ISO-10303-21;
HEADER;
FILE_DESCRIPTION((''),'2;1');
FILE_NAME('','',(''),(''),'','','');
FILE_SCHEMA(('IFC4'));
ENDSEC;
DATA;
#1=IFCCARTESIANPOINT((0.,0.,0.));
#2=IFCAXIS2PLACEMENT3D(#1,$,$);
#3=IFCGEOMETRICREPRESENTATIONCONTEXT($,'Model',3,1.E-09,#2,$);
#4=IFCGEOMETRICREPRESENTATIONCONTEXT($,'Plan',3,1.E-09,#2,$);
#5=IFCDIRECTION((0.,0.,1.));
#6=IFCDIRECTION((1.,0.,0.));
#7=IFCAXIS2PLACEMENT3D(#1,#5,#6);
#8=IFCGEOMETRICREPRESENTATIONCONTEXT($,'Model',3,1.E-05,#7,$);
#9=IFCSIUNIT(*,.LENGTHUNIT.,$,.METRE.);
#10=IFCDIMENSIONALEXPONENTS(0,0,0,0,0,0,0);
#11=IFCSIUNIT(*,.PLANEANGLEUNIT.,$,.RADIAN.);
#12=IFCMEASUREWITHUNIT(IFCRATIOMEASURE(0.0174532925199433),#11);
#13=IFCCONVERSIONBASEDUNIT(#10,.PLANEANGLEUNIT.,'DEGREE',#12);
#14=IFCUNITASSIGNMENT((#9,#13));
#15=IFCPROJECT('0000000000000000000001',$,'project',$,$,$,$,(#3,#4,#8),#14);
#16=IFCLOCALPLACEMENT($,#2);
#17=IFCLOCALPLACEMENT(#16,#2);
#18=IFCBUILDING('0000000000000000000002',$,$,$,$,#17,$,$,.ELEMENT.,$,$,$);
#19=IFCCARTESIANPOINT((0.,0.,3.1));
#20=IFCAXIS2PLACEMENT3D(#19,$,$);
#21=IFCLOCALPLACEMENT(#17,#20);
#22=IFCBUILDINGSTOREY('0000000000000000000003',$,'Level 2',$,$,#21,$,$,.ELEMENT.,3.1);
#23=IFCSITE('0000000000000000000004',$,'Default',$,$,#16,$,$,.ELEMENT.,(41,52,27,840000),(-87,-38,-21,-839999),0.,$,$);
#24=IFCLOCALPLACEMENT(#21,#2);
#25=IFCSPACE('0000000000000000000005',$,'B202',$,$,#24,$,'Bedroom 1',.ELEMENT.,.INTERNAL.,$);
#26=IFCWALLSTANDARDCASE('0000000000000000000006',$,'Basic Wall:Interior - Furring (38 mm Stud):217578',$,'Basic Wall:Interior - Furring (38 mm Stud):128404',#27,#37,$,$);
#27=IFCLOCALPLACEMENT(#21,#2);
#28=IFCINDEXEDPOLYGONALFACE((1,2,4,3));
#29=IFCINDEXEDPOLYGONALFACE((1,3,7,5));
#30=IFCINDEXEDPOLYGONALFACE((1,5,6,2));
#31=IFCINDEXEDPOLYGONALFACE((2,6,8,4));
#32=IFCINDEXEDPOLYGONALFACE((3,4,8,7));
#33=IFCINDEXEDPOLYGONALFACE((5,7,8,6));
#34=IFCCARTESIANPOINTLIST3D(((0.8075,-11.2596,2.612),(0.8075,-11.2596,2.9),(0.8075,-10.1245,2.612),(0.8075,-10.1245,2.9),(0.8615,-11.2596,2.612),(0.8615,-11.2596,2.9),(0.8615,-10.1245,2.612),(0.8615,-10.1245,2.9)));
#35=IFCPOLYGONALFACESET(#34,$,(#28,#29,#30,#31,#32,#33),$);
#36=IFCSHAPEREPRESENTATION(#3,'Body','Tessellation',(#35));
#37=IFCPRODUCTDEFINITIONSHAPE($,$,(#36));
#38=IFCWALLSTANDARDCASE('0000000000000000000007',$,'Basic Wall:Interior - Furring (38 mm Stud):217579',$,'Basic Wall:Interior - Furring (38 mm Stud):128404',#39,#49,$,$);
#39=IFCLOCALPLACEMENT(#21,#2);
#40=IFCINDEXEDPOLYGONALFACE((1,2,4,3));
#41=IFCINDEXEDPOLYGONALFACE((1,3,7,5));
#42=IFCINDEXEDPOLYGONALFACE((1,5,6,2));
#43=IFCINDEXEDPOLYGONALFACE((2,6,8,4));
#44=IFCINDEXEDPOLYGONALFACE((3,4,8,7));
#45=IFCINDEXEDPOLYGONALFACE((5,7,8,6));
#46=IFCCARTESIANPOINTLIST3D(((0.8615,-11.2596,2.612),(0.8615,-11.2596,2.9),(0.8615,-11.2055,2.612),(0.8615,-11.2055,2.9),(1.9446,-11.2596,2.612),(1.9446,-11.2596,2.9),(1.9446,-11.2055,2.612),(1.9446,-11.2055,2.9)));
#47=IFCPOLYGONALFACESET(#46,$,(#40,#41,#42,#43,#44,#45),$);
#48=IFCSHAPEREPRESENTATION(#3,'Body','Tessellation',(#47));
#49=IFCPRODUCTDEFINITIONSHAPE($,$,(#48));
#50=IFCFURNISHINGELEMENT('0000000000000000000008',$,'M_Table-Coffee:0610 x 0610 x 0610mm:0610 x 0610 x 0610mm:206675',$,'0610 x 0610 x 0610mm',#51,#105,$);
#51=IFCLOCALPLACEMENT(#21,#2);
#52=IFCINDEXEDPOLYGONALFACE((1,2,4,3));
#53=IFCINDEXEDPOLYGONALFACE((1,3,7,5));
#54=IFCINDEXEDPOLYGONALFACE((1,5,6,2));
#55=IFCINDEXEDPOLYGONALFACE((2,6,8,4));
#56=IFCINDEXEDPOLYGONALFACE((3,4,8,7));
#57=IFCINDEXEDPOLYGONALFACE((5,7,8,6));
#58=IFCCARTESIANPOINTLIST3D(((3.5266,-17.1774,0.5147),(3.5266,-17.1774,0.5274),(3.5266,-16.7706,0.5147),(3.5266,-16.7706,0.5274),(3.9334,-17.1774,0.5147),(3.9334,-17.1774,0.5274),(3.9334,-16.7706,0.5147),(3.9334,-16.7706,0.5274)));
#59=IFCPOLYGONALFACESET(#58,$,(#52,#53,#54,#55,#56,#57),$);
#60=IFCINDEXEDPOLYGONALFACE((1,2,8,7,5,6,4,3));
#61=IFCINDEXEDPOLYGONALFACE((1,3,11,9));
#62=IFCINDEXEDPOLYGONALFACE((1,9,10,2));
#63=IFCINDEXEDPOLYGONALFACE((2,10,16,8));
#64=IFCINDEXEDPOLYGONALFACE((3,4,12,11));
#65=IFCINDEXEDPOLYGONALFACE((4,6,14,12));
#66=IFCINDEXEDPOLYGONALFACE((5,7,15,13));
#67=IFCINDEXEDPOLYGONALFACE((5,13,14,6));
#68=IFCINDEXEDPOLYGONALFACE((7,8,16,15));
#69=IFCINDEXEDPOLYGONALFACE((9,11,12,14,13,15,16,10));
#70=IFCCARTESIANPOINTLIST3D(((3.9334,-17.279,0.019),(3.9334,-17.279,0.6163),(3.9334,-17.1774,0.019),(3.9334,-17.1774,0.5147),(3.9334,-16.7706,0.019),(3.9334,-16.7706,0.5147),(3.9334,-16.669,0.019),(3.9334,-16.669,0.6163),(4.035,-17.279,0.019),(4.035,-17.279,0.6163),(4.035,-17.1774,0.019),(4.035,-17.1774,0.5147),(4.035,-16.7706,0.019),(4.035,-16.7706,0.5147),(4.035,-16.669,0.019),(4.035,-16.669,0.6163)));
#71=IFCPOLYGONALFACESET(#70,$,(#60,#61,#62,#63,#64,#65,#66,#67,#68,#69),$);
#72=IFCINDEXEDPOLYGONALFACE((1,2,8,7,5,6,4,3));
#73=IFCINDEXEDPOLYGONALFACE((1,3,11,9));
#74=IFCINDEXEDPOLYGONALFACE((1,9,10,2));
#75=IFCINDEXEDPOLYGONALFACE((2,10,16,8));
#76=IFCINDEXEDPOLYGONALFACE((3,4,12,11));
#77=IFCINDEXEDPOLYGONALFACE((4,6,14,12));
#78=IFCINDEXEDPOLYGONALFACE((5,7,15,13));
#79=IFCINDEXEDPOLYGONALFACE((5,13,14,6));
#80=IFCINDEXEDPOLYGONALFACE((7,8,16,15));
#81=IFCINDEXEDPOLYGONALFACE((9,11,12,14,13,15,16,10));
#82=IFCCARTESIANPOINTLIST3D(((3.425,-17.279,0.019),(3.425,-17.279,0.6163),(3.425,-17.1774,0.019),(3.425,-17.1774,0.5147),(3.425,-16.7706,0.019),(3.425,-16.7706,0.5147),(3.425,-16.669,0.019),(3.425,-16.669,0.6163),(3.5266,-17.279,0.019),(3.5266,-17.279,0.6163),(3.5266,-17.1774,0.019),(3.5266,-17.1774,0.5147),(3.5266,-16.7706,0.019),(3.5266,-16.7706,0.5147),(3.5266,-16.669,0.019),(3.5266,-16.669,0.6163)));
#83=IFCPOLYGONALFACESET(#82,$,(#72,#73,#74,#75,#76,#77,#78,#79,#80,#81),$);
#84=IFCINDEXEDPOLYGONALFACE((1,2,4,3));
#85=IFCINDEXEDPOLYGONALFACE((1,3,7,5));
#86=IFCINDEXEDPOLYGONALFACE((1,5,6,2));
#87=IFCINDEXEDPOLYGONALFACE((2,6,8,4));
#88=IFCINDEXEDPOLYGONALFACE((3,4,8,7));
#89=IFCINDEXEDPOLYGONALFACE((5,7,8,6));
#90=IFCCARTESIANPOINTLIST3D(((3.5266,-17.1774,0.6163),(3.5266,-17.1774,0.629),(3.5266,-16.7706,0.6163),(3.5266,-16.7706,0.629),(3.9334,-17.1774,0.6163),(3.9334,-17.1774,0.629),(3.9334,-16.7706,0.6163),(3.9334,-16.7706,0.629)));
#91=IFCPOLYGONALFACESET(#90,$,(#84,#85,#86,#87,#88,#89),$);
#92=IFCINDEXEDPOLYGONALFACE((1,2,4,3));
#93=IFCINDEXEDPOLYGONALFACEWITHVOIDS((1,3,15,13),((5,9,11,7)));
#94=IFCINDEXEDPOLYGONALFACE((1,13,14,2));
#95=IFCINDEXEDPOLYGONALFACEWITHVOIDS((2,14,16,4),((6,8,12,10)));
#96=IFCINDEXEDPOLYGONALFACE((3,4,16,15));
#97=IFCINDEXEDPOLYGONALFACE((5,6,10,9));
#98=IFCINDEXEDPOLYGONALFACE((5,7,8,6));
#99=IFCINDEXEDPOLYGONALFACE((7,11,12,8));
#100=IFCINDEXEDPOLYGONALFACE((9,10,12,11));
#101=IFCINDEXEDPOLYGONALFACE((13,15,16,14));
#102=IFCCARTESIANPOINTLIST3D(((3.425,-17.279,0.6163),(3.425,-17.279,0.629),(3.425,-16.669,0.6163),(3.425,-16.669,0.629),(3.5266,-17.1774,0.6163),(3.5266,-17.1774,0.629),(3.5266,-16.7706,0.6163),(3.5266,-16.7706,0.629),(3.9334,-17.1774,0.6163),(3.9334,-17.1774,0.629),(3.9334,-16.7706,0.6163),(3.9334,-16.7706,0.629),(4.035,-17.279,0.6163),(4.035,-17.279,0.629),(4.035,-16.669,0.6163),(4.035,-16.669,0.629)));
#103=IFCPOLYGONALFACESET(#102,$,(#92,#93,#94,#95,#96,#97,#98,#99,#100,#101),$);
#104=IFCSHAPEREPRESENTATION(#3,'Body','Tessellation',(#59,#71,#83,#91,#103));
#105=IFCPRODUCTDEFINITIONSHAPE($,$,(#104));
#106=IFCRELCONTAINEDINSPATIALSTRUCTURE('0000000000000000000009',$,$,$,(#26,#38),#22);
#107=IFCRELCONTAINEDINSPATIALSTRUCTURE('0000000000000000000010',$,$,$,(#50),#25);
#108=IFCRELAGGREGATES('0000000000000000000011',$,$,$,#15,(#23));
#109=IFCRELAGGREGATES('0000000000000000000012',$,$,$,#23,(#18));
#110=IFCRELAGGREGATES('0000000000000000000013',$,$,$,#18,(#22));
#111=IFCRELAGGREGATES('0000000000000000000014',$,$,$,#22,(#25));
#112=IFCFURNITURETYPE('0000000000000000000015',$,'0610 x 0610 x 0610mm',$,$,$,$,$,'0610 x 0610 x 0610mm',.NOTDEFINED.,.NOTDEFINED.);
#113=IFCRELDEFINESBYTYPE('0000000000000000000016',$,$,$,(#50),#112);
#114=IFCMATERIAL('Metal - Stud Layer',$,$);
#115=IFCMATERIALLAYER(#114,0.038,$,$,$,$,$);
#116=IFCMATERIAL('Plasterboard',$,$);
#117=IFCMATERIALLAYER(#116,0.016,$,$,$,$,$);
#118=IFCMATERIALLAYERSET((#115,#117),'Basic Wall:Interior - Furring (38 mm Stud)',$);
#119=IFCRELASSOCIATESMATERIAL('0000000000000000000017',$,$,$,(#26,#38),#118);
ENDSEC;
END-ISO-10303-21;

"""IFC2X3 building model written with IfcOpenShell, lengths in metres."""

from ifc_helpers import new_model, entity, si_unit, converted_unit, frame, frame_2d, origin, origin_with_axes, origin_2d_with_axis, place, context, project, spatial, polyline, rectangle, outline, extrude, source, transform, mapped, material, layer, layer_set, layer_usage, type_object, type_shapes, element, save


model = new_model("IFC2X3")

# Units and contexts
model_context_1 = context("Model", 3, precision=1e-09, world=origin())
plan_context = context("Plan", 3, precision=1e-09, world=origin())
model_context_2 = context("Model", 3, precision=1e-05, world=origin_with_axes())
ifc_project = project(units=[si_unit("LENGTHUNIT", "METRE"), converted_unit("PLANEANGLEUNIT", "DEGREE", entity("IfcRatioMeasure", 0.0174532925199433), si_unit("PLANEANGLEUNIT", "RADIAN"), dimensions=[0, 0, 0, 0, 0, 0, 0])], contexts=[model_context_1, plan_context, model_context_2])

# Site, building, storey
site_placement = place(None, origin())
site = spatial("IfcSite", under=ifc_project, at=site_placement, Name="Default", CompositionType="ELEMENT", RefLatitude=(41, 52, 27, 840000), RefLongitude=(-87, -38, -21, -839999), RefElevation=0.0)
building_placement = place(site_placement, origin())
building = spatial("IfcBuilding", under=site, at=building_placement, CompositionType="ELEMENT")
storey_placement = place(building_placement, frame((0.0, 0.0, 3.1)))
storey = spatial("IfcBuildingStorey", under=building, at=storey_placement, Name="Level 2", CompositionType="ELEMENT", Elevation=3.1)

# Shared definitions
ifc_material_1 = material(Name="Metal - Stud Layer")
ifc_material_2 = material(Name="Plasterboard")

# Walls
ifc_layer_1 = layer(ifc_material_1, 0.038)
ifc_layer_2 = layer(ifc_material_2, 0.016)
ifc_layer_set_1 = layer_set([ifc_layer_1, ifc_layer_2], Name="Basic Wall:Interior - Furring (38 mm Stud)")
ifc_layer_usage_1 = layer_usage(ifc_layer_set_1, "AXIS2", "NEGATIVE", 0.027)
wall_1_placement = place(storey_placement, frame((0.8345, -11.2596, 2.612), z_axis=(0.0, 0.0, 1.0), x_axis=(0.0, 1.0, 0.0)))
element("IfcWallStandardCase", 1, at=wall_1_placement, inside=storey, material=ifc_layer_usage_1, Name="Basic Wall:Interior - Furring (38 mm Stud):217578", ObjectType="Basic Wall:Interior - Furring (38 mm Stud):128404", context=model_context_1, shape_type="SweptSolid", body=[
    extrude(rectangle(XDim=1.1351, YDim=0.054, at=frame_2d((0.5675, 0.0), x_axis=(-1.0, 0.0))), origin(), (0.0, 0.0, 1.0), 0.288),
])
ifc_layer_usage_2 = layer_usage(ifc_layer_set_1, "AXIS2", "NEGATIVE", 0.027)
wall_2_placement = place(storey_placement, frame((1.9446, -11.2325, 2.612), z_axis=(0.0, 0.0, 1.0), x_axis=(-1.0, 0.0, 0.0)))
element("IfcWallStandardCase", 2, at=wall_2_placement, inside=storey, material=ifc_layer_usage_2, Name="Basic Wall:Interior - Furring (38 mm Stud):217579", ObjectType="Basic Wall:Interior - Furring (38 mm Stud):128404", context=model_context_1, shape_type="SweptSolid", body=[
    extrude(rectangle(XDim=1.0831, YDim=0.054, at=frame_2d((0.5415, 0.0), x_axis=(-1.0, 0.0))), origin(), (0.0, 0.0, 1.0), 0.288),
])

# Shared definitions
space_placement = place(storey_placement, origin())
space = spatial("IfcSpace", under=storey, at=space_placement, Name="B202", LongName="Bedroom 1", CompositionType="ELEMENT", InteriorOrExteriorSpace="INTERNAL")

# Furnishing element
furniture_type = type_object("IfcFurnitureType", Name="0610 x 0610 x 0610mm", ElementType="0610 x 0610 x 0610mm", AssemblyPlace="NOTDEFINED")
shared_shape_1 = source(origin(), model_context_1, "Body", "SweptSolid", [
    extrude(rectangle(XDim=0.4068, YDim=0.4068, at=origin_2d_with_axis()), frame((0.0183, 0.0952, 0.4957), z_axis=(0.0, 0.0, 1.0), x_axis=(-1.0, 0.0, 0.0)), (0.0, 0.0, 1.0), 0.0127),
    extrude(outline(polyline([(-0.2732, -0.305), (0.324, -0.305), (0.324, 0.305), (-0.2732, 0.305), (-0.2732, 0.2034), (0.2225, 0.2034), (0.2225, -0.2034), (-0.2732, -0.2034), (-0.2732, -0.305)])), frame((0.2217, 0.0952, 0.2732), z_axis=(1.0, 0.0, 0.0), x_axis=(0.0, 0.0, 1.0)), (0.0, 0.0, 1.0), 0.1016),
    extrude(outline(polyline([(-0.305, -0.3241), (0.305, -0.3241), (0.305, 0.2733), (0.2034, 0.2733), (0.2034, -0.2224), (-0.2034, -0.2224), (-0.2034, 0.2733), (-0.305, 0.2733), (-0.305, -0.3241)])), frame((-0.2867, 0.0952, 0.2733), z_axis=(1.0, 0.0, 0.0), x_axis=(0.0, -1.0, 0.0)), (0.0, 0.0, 1.0), 0.1016),
    extrude(rectangle(XDim=0.4068, YDim=0.4068, at=origin_2d_with_axis()), frame((0.0183, 0.0952, 0.5973), z_axis=(0.0, 0.0, 1.0), x_axis=(-1.0, 0.0, 0.0)), (0.0, 0.0, 1.0), 0.0127),
    extrude(outline(polyline([(-0.305, -0.305), (0.305, -0.305), (0.305, 0.305), (-0.305, 0.305), (-0.305, -0.305)]), holes=[polyline([(-0.2034, -0.2034), (-0.2034, 0.2034), (0.2034, 0.2034), (0.2034, -0.2034), (-0.2034, -0.2034)])]), frame((0.0183, 0.0952, 0.5973), z_axis=(0.0, 0.0, 1.0), x_axis=(-1.0, 0.0, 0.0)), (0.0, 0.0, 1.0), 0.0127),
])
type_shapes(furniture_type, [shared_shape_1])
furnishing_placement = place(space_placement, frame((3.7117, -17.0692, 0.019)))
element("IfcFurnishingElement", 3, at=furnishing_placement, inside=space, type_object=furniture_type, Name="M_Table-Coffee:0610 x 0610 x 0610mm:0610 x 0610 x 0610mm:206675", ObjectType="0610 x 0610 x 0610mm", context=model_context_1, shape_type="MappedRepresentation", body=[
    mapped(shared_shape_1, transform((0.0, 0.0, 0.0), scale=1.0)),
])

save(model, "model.ifc")
